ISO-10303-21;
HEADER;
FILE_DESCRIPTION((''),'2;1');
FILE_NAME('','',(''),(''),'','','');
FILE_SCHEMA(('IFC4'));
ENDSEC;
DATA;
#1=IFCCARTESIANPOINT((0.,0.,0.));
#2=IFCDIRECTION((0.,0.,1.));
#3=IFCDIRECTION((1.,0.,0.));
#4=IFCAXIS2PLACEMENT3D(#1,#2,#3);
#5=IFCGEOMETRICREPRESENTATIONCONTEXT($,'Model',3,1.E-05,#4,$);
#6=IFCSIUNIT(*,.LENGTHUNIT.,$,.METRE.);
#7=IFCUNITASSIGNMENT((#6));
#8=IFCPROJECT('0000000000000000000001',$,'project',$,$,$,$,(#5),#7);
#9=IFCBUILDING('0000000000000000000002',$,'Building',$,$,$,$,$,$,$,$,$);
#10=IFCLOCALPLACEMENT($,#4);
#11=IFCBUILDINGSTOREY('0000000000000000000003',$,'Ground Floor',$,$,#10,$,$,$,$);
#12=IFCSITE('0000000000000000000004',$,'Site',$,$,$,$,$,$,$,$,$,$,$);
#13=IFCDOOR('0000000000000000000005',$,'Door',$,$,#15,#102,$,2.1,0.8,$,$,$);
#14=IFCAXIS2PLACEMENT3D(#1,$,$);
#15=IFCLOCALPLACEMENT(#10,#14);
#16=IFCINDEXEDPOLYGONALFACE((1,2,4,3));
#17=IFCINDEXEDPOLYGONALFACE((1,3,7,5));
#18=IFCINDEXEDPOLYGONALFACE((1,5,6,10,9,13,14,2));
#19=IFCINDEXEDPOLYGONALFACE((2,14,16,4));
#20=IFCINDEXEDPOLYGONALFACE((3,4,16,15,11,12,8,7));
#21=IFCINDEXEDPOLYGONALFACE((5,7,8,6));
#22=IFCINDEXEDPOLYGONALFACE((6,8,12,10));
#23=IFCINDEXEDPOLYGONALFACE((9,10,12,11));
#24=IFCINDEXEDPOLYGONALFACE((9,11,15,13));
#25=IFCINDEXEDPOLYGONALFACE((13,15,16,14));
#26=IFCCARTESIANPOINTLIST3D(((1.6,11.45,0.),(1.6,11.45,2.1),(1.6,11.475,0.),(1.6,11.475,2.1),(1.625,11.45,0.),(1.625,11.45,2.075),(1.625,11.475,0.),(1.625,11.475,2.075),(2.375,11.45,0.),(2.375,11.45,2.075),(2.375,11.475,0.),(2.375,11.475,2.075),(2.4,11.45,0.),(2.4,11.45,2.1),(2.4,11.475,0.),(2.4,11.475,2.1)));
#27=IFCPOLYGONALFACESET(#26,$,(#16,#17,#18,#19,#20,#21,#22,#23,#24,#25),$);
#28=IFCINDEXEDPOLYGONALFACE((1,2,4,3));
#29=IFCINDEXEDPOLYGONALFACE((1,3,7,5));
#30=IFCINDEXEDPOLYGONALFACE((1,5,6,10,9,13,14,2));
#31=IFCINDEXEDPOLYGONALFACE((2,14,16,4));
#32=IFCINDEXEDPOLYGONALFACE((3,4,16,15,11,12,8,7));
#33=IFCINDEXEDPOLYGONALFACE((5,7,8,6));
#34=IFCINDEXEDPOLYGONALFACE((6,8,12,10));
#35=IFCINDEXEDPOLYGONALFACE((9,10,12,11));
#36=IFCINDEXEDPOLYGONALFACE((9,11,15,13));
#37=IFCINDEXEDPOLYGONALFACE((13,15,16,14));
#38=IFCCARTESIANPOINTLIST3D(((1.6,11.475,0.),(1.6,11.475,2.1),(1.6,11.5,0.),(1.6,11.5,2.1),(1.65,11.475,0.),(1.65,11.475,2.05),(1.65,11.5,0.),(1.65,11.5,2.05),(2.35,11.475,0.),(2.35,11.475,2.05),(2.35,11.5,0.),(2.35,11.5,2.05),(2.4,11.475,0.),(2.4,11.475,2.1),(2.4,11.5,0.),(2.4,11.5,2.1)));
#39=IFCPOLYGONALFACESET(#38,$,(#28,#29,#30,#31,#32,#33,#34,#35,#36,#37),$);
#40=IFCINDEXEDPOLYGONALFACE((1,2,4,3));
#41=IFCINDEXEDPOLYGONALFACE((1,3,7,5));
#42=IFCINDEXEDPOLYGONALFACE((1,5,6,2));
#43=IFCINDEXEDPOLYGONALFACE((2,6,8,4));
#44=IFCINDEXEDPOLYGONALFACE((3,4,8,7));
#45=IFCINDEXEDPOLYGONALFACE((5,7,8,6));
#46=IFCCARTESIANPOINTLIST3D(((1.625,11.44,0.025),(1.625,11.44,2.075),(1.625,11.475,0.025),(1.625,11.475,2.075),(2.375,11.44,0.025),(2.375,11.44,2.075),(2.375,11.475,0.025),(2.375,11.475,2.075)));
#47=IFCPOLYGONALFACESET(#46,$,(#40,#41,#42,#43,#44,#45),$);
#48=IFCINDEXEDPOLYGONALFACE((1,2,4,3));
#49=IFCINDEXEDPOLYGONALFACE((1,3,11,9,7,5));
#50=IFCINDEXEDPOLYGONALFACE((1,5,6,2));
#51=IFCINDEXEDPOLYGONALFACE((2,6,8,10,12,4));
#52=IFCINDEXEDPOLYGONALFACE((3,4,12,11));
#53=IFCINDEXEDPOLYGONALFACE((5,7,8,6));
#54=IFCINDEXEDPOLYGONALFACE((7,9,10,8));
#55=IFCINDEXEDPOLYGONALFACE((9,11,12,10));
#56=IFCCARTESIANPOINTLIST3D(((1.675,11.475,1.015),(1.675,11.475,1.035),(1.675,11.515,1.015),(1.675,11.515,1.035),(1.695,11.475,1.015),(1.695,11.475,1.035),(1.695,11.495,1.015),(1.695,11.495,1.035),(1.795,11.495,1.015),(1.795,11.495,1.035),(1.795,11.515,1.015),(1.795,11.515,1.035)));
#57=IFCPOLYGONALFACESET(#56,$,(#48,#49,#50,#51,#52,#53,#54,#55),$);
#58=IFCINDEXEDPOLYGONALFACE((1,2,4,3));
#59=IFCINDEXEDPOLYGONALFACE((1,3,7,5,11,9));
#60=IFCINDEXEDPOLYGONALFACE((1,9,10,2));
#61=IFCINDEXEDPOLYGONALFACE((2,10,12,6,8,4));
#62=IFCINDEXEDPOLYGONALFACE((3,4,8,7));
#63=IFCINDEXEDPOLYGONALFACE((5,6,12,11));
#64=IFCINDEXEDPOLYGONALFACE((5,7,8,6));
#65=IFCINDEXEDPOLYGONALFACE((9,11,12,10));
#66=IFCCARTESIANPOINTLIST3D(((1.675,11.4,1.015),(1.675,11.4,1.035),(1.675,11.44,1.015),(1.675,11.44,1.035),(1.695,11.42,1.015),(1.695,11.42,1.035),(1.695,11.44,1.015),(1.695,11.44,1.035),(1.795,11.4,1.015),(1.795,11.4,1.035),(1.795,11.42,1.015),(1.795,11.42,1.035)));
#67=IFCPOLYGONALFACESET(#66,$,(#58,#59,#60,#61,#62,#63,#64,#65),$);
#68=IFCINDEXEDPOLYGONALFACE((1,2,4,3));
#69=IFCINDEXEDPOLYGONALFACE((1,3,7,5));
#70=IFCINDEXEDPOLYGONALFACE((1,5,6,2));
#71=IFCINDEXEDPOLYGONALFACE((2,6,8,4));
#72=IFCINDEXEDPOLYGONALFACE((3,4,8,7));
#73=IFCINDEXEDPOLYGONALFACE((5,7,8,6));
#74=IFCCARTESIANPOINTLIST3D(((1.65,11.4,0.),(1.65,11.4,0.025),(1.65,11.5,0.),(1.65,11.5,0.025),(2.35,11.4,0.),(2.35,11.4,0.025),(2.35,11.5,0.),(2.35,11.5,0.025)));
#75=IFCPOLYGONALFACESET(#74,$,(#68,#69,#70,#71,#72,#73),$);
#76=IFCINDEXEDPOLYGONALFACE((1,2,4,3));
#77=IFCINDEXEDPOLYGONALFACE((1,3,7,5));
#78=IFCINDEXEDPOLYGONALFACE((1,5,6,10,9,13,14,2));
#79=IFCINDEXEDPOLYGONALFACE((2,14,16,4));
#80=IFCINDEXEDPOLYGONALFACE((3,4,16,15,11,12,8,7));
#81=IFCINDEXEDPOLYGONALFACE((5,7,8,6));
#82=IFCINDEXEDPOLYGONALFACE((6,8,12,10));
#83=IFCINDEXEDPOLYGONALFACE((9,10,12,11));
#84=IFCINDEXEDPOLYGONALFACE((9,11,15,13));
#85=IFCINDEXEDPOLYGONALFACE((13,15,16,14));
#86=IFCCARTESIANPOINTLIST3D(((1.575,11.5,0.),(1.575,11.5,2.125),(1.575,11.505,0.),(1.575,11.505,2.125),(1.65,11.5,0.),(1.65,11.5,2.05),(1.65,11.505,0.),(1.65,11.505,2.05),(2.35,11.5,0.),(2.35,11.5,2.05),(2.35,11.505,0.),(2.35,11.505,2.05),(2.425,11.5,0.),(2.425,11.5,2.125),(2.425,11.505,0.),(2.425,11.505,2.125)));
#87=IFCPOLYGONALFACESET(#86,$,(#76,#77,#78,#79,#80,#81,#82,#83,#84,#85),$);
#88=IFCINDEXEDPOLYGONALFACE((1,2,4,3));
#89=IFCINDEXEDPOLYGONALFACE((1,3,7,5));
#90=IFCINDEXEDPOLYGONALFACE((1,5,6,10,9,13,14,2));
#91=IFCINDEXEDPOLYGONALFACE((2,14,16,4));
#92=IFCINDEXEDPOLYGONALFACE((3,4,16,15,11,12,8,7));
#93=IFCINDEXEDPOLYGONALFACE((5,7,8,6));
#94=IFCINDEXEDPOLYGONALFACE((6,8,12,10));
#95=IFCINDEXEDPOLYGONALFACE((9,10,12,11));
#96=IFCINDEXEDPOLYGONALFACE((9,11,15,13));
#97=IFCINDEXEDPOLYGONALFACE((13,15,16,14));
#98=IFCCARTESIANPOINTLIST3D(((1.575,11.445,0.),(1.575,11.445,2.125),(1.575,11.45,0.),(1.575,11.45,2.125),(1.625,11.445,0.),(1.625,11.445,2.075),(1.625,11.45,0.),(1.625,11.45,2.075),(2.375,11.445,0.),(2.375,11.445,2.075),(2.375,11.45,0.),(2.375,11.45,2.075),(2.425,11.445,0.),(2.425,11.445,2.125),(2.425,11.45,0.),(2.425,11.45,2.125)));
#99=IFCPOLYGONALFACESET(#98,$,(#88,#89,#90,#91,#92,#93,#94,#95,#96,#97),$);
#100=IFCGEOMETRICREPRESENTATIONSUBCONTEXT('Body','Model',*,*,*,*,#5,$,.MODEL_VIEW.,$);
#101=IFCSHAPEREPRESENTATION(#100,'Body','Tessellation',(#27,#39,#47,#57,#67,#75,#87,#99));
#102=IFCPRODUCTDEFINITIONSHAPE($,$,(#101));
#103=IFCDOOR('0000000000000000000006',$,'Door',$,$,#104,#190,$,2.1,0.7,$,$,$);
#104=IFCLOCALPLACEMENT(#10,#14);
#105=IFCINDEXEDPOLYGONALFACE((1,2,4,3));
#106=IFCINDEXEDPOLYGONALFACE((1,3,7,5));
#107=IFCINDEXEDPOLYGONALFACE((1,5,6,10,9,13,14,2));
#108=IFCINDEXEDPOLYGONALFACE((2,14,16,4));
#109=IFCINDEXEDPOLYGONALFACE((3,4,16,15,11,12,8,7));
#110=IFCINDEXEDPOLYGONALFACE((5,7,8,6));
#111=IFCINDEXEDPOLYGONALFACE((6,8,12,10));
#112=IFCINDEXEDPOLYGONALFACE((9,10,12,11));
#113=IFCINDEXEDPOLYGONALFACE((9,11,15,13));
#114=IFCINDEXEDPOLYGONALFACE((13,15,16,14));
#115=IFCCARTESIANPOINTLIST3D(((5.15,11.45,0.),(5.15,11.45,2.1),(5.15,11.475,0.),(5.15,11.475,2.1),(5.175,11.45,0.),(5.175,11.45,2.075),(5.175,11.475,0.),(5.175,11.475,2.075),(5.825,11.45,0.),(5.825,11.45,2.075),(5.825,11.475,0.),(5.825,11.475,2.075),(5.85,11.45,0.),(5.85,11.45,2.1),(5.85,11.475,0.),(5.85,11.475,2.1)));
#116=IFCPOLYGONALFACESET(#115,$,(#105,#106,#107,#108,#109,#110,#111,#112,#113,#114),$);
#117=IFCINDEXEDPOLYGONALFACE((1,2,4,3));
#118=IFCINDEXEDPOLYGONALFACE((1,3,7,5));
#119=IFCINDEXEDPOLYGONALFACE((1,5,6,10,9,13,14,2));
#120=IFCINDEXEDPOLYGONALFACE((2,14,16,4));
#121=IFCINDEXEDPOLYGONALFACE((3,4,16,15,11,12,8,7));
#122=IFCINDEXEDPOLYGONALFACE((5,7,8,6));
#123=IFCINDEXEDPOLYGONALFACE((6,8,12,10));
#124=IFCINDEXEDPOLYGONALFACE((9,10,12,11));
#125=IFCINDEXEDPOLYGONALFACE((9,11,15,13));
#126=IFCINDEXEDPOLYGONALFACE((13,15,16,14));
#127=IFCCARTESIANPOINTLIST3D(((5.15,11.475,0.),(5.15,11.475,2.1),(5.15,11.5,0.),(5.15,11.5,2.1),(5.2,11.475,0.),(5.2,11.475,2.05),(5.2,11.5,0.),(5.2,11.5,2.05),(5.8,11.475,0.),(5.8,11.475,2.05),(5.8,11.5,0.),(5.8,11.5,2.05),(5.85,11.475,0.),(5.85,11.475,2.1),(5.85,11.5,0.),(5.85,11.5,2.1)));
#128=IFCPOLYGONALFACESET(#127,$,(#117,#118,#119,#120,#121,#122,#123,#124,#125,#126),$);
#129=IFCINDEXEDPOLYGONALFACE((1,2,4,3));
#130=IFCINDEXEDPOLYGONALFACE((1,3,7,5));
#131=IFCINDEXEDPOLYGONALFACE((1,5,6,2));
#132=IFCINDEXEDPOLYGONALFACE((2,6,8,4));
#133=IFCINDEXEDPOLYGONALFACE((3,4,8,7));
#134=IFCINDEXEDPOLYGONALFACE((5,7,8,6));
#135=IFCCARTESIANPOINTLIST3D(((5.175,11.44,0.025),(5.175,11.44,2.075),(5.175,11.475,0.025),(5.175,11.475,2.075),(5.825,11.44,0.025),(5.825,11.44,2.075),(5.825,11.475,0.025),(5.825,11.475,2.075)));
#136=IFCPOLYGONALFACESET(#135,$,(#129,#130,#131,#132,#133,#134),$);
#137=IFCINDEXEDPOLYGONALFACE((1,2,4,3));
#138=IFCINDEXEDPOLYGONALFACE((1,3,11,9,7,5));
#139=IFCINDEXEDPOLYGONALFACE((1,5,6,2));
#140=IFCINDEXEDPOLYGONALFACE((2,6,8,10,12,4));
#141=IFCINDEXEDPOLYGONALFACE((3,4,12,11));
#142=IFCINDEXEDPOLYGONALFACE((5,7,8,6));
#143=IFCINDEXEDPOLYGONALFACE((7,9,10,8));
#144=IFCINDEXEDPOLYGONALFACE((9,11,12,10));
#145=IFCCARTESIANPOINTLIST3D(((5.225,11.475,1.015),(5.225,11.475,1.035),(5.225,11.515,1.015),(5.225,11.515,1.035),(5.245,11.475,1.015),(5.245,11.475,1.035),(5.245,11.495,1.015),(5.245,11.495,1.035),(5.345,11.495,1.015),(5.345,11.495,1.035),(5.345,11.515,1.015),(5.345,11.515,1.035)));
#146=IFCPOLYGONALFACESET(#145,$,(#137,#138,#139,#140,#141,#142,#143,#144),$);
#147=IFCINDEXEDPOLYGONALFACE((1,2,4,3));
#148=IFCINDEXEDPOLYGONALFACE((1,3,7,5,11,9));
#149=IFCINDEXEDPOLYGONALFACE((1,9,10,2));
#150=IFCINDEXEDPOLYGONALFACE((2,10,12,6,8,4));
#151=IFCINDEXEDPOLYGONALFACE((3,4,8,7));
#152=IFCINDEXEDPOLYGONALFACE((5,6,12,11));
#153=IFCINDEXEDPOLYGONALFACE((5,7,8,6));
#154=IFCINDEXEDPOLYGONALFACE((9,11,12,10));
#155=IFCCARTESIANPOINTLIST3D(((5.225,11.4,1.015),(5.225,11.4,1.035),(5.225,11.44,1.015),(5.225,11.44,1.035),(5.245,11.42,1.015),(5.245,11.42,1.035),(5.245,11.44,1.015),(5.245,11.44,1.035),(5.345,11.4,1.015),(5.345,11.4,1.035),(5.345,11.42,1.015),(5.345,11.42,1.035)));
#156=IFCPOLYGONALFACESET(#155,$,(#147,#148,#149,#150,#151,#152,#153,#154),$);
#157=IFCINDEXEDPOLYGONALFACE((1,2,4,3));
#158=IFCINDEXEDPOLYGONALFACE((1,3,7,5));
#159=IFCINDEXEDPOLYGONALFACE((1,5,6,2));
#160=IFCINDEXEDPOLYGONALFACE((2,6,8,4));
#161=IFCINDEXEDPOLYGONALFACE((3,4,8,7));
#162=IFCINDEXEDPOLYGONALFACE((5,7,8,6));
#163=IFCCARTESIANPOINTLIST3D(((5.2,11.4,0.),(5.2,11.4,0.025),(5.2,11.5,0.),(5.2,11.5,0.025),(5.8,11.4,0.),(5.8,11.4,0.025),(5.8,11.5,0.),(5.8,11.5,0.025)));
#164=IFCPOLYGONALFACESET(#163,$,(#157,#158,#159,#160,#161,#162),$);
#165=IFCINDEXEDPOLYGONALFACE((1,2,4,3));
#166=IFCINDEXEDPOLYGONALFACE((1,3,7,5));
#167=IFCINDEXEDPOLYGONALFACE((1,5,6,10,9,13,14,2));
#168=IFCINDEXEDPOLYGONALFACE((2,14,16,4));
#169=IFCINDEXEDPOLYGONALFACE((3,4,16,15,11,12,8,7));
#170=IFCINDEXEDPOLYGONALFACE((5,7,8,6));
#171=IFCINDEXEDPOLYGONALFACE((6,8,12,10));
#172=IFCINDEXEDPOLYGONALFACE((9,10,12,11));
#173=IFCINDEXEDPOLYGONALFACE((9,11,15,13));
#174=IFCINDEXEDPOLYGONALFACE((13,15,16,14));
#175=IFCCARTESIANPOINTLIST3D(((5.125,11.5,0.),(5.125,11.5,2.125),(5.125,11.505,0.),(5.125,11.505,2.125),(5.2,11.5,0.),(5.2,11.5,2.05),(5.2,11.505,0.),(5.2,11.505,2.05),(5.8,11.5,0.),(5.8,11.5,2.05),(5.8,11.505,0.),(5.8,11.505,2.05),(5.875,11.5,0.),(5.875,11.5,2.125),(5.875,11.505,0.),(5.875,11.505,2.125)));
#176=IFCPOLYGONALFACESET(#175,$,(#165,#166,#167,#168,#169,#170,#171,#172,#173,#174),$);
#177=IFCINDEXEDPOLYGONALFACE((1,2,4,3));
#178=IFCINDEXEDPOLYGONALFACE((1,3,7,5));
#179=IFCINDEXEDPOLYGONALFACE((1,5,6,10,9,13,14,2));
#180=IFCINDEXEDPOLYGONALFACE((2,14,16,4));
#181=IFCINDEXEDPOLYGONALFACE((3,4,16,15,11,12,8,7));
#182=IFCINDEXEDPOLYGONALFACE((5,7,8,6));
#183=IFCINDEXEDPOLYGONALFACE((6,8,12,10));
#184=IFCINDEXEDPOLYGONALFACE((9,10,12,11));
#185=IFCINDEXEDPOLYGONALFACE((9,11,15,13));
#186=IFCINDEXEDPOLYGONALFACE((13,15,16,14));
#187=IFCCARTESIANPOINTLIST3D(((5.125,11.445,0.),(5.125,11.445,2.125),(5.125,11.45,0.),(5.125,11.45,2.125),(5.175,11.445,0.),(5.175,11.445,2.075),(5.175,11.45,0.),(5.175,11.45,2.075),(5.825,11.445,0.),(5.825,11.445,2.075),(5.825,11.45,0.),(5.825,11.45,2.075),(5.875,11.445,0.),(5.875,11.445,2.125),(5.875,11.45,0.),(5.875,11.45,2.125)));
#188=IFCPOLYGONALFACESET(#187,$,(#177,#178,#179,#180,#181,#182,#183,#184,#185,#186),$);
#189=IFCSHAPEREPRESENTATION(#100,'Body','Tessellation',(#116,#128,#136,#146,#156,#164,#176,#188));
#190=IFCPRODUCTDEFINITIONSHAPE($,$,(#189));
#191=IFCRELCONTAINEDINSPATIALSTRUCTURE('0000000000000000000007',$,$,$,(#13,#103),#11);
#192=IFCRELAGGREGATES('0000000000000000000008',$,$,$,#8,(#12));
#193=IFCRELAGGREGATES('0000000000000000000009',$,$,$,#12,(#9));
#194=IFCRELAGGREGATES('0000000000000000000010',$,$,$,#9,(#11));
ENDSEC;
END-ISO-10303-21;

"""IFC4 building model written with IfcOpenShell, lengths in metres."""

from ifc_helpers import new_model, si_unit, frame, origin_with_axes, place, context, subcontext, project, spatial, line, indexed_curve, outline, extrude, element, save


model = new_model("IFC4")

# Units and contexts
model_context = context("Model", 3, precision=1e-05, world=origin_with_axes())
body_context = subcontext(model_context, "Body", "Model", "MODEL_VIEW")
ifc_project = project(units=[si_unit("LENGTHUNIT", "METRE")], contexts=[model_context])

# Site, building, storey
site = spatial("IfcSite", under=ifc_project, Name="Site")
building = spatial("IfcBuilding", under=site, Name="Building")
storey_placement = place(None, origin_with_axes())
storey = spatial("IfcBuildingStorey", under=building, at=storey_placement, Name="Ground Floor")

# Doors
door_1_placement = place(storey_placement, frame((2.4, 11.5, 0.0), z_axis=(0.0, 0.0, 1.0), x_axis=(-1.0, 0.0, 0.0)))
element("IfcDoor", 1, at=door_1_placement, inside=storey, Name="Door", OverallHeight=2.1, OverallWidth=0.8, context=body_context, shape_type="SweptSolid", body=[
    extrude(outline(indexed_curve([(0.0, 0.0), (0.0, 2.1), (0.8, 2.1), (0.8, 0.0), (0.775, 0.0), (0.775, 2.075), (0.025, 2.075), (0.025, 0.0)], segments=[line(1, 2, 3, 4, 5, 6, 7, 8, 1)])), frame((0.0, 0.025, 0.0), z_axis=(0.0, -1.0, 0.0), x_axis=(1.0, 0.0, 0.0)), (0.0, 0.0, -1.0), 0.025),
    extrude(outline(indexed_curve([(0.0, 0.0), (0.0, 2.1), (0.8, 2.1), (0.8, 0.0), (0.75, 0.0), (0.75, 2.05), (0.05, 2.05), (0.05, 0.0)], segments=[line(1, 2, 3, 4, 5, 6, 7, 8, 1)])), frame((0.0, 0.0, 0.0), z_axis=(0.0, -1.0, 0.0), x_axis=(1.0, 0.0, 0.0)), (0.0, 0.0, -1.0), 0.025),
    extrude(outline(indexed_curve([(0.0, 0.0), (0.75, 0.0), (0.75, 0.035), (0.0, 0.035)], segments=[line(1, 2, 3, 4, 1)])), frame((0.025, 0.025, 0.025), z_axis=(0.0, 0.0, 1.0), x_axis=(1.0, 0.0, 0.0)), (0.0, 0.0, 1.0), 2.05),
    extrude(outline(indexed_curve([(0.0, 0.0), (0.0, -0.04), (-0.12, -0.04), (-0.12, -0.02), (-0.02, -0.02), (-0.02, 0.0)], segments=[line(1, 2, 3, 4, 5, 6, 1)])), frame((0.725, 0.025, 1.015), z_axis=(0.0, 0.0, 1.0), x_axis=(1.0, 0.0, 0.0)), (0.0, 0.0, 1.0), 0.02),
    extrude(outline(indexed_curve([(0.0, 0.0), (0.0, 0.04), (-0.12, 0.04), (-0.12, 0.02), (-0.02, 0.02), (-0.02, 0.0)], segments=[line(1, 2, 3, 4, 5, 6, 1)])), frame((0.725, 0.06, 1.015), z_axis=(0.0, 0.0, 1.0), x_axis=(1.0, 0.0, 0.0)), (0.0, 0.0, 1.0), 0.02),
    extrude(outline(indexed_curve([(0.0, 0.0), (0.7, 0.0), (0.7, 0.1), (0.0, 0.1)], segments=[line(1, 2, 3, 4, 1)])), frame((0.05, 0.0, 0.0), z_axis=(0.0, 0.0, 1.0), x_axis=(1.0, 0.0, 0.0)), (0.0, 0.0, 1.0), 0.025),
    extrude(outline(indexed_curve([(0.0, 0.0), (0.0, 2.125), (0.85, 2.125), (0.85, 0.0), (0.775, 0.0), (0.775, 2.05), (0.075, 2.05), (0.075, 0.0)], segments=[line(1, 2, 3, 4, 5, 6, 7, 8, 1)])), frame((-0.025, -0.005, 0.0), z_axis=(0.0, -1.0, 0.0), x_axis=(1.0, 0.0, 0.0)), (0.0, 0.0, -1.0), 0.005),
    extrude(outline(indexed_curve([(0.0, 0.0), (0.0, 2.125), (0.85, 2.125), (0.85, 0.0), (0.8, 0.0), (0.8, 2.075), (0.05, 2.075), (0.05, 0.0)], segments=[line(1, 2, 3, 4, 5, 6, 7, 8, 1)])), frame((-0.025, 0.05, 0.0), z_axis=(0.0, -1.0, 0.0), x_axis=(1.0, 0.0, 0.0)), (0.0, 0.0, -1.0), 0.005),
])
door_2_placement = place(storey_placement, frame((5.85, 11.5, 0.0), z_axis=(0.0, 0.0, 1.0), x_axis=(-1.0, 0.0, 0.0)))
element("IfcDoor", 2, at=door_2_placement, inside=storey, Name="Door", OverallHeight=2.1, OverallWidth=0.7, context=body_context, shape_type="SweptSolid", body=[
    extrude(outline(indexed_curve([(0.0, 0.0), (0.0, 2.1), (0.7, 2.1), (0.7, 0.0), (0.675, 0.0), (0.675, 2.075), (0.025, 2.075), (0.025, 0.0)], segments=[line(1, 2, 3, 4, 5, 6, 7, 8, 1)])), frame((0.0, 0.025, 0.0), z_axis=(0.0, -1.0, 0.0), x_axis=(1.0, 0.0, 0.0)), (0.0, 0.0, -1.0), 0.025),
    extrude(outline(indexed_curve([(0.0, 0.0), (0.0, 2.1), (0.7, 2.1), (0.7, 0.0), (0.65, 0.0), (0.65, 2.05), (0.05, 2.05), (0.05, 0.0)], segments=[line(1, 2, 3, 4, 5, 6, 7, 8, 1)])), frame((0.0, 0.0, 0.0), z_axis=(0.0, -1.0, 0.0), x_axis=(1.0, 0.0, 0.0)), (0.0, 0.0, -1.0), 0.025),
    extrude(outline(indexed_curve([(0.0, 0.0), (0.65, 0.0), (0.65, 0.035), (0.0, 0.035)], segments=[line(1, 2, 3, 4, 1)])), frame((0.025, 0.025, 0.025), z_axis=(0.0, 0.0, 1.0), x_axis=(1.0, 0.0, 0.0)), (0.0, 0.0, 1.0), 2.05),
    extrude(outline(indexed_curve([(0.0, 0.0), (0.0, -0.04), (-0.12, -0.04), (-0.12, -0.02), (-0.02, -0.02), (-0.02, 0.0)], segments=[line(1, 2, 3, 4, 5, 6, 1)])), frame((0.625, 0.025, 1.015), z_axis=(0.0, 0.0, 1.0), x_axis=(1.0, 0.0, 0.0)), (0.0, 0.0, 1.0), 0.02),
    extrude(outline(indexed_curve([(0.0, 0.0), (0.0, 0.04), (-0.12, 0.04), (-0.12, 0.02), (-0.02, 0.02), (-0.02, 0.0)], segments=[line(1, 2, 3, 4, 5, 6, 1)])), frame((0.625, 0.06, 1.015), z_axis=(0.0, 0.0, 1.0), x_axis=(1.0, 0.0, 0.0)), (0.0, 0.0, 1.0), 0.02),
    extrude(outline(indexed_curve([(0.0, 0.0), (0.6, 0.0), (0.6, 0.1), (0.0, 0.1)], segments=[line(1, 2, 3, 4, 1)])), frame((0.05, 0.0, 0.0), z_axis=(0.0, 0.0, 1.0), x_axis=(1.0, 0.0, 0.0)), (0.0, 0.0, 1.0), 0.025),
    extrude(outline(indexed_curve([(0.0, 0.0), (0.0, 2.125), (0.75, 2.125), (0.75, 0.0), (0.675, 0.0), (0.675, 2.05), (0.075, 2.05), (0.075, 0.0)], segments=[line(1, 2, 3, 4, 5, 6, 7, 8, 1)])), frame((-0.025, -0.005, 0.0), z_axis=(0.0, -1.0, 0.0), x_axis=(1.0, 0.0, 0.0)), (0.0, 0.0, -1.0), 0.005),
    extrude(outline(indexed_curve([(0.0, 0.0), (0.0, 2.125), (0.75, 2.125), (0.75, 0.0), (0.7, 0.0), (0.7, 2.075), (0.05, 2.075), (0.05, 0.0)], segments=[line(1, 2, 3, 4, 5, 6, 7, 8, 1)])), frame((-0.025, 0.05, 0.0), z_axis=(0.0, -1.0, 0.0), x_axis=(1.0, 0.0, 0.0)), (0.0, 0.0, -1.0), 0.005),
])

save(model, "model.ifc")
